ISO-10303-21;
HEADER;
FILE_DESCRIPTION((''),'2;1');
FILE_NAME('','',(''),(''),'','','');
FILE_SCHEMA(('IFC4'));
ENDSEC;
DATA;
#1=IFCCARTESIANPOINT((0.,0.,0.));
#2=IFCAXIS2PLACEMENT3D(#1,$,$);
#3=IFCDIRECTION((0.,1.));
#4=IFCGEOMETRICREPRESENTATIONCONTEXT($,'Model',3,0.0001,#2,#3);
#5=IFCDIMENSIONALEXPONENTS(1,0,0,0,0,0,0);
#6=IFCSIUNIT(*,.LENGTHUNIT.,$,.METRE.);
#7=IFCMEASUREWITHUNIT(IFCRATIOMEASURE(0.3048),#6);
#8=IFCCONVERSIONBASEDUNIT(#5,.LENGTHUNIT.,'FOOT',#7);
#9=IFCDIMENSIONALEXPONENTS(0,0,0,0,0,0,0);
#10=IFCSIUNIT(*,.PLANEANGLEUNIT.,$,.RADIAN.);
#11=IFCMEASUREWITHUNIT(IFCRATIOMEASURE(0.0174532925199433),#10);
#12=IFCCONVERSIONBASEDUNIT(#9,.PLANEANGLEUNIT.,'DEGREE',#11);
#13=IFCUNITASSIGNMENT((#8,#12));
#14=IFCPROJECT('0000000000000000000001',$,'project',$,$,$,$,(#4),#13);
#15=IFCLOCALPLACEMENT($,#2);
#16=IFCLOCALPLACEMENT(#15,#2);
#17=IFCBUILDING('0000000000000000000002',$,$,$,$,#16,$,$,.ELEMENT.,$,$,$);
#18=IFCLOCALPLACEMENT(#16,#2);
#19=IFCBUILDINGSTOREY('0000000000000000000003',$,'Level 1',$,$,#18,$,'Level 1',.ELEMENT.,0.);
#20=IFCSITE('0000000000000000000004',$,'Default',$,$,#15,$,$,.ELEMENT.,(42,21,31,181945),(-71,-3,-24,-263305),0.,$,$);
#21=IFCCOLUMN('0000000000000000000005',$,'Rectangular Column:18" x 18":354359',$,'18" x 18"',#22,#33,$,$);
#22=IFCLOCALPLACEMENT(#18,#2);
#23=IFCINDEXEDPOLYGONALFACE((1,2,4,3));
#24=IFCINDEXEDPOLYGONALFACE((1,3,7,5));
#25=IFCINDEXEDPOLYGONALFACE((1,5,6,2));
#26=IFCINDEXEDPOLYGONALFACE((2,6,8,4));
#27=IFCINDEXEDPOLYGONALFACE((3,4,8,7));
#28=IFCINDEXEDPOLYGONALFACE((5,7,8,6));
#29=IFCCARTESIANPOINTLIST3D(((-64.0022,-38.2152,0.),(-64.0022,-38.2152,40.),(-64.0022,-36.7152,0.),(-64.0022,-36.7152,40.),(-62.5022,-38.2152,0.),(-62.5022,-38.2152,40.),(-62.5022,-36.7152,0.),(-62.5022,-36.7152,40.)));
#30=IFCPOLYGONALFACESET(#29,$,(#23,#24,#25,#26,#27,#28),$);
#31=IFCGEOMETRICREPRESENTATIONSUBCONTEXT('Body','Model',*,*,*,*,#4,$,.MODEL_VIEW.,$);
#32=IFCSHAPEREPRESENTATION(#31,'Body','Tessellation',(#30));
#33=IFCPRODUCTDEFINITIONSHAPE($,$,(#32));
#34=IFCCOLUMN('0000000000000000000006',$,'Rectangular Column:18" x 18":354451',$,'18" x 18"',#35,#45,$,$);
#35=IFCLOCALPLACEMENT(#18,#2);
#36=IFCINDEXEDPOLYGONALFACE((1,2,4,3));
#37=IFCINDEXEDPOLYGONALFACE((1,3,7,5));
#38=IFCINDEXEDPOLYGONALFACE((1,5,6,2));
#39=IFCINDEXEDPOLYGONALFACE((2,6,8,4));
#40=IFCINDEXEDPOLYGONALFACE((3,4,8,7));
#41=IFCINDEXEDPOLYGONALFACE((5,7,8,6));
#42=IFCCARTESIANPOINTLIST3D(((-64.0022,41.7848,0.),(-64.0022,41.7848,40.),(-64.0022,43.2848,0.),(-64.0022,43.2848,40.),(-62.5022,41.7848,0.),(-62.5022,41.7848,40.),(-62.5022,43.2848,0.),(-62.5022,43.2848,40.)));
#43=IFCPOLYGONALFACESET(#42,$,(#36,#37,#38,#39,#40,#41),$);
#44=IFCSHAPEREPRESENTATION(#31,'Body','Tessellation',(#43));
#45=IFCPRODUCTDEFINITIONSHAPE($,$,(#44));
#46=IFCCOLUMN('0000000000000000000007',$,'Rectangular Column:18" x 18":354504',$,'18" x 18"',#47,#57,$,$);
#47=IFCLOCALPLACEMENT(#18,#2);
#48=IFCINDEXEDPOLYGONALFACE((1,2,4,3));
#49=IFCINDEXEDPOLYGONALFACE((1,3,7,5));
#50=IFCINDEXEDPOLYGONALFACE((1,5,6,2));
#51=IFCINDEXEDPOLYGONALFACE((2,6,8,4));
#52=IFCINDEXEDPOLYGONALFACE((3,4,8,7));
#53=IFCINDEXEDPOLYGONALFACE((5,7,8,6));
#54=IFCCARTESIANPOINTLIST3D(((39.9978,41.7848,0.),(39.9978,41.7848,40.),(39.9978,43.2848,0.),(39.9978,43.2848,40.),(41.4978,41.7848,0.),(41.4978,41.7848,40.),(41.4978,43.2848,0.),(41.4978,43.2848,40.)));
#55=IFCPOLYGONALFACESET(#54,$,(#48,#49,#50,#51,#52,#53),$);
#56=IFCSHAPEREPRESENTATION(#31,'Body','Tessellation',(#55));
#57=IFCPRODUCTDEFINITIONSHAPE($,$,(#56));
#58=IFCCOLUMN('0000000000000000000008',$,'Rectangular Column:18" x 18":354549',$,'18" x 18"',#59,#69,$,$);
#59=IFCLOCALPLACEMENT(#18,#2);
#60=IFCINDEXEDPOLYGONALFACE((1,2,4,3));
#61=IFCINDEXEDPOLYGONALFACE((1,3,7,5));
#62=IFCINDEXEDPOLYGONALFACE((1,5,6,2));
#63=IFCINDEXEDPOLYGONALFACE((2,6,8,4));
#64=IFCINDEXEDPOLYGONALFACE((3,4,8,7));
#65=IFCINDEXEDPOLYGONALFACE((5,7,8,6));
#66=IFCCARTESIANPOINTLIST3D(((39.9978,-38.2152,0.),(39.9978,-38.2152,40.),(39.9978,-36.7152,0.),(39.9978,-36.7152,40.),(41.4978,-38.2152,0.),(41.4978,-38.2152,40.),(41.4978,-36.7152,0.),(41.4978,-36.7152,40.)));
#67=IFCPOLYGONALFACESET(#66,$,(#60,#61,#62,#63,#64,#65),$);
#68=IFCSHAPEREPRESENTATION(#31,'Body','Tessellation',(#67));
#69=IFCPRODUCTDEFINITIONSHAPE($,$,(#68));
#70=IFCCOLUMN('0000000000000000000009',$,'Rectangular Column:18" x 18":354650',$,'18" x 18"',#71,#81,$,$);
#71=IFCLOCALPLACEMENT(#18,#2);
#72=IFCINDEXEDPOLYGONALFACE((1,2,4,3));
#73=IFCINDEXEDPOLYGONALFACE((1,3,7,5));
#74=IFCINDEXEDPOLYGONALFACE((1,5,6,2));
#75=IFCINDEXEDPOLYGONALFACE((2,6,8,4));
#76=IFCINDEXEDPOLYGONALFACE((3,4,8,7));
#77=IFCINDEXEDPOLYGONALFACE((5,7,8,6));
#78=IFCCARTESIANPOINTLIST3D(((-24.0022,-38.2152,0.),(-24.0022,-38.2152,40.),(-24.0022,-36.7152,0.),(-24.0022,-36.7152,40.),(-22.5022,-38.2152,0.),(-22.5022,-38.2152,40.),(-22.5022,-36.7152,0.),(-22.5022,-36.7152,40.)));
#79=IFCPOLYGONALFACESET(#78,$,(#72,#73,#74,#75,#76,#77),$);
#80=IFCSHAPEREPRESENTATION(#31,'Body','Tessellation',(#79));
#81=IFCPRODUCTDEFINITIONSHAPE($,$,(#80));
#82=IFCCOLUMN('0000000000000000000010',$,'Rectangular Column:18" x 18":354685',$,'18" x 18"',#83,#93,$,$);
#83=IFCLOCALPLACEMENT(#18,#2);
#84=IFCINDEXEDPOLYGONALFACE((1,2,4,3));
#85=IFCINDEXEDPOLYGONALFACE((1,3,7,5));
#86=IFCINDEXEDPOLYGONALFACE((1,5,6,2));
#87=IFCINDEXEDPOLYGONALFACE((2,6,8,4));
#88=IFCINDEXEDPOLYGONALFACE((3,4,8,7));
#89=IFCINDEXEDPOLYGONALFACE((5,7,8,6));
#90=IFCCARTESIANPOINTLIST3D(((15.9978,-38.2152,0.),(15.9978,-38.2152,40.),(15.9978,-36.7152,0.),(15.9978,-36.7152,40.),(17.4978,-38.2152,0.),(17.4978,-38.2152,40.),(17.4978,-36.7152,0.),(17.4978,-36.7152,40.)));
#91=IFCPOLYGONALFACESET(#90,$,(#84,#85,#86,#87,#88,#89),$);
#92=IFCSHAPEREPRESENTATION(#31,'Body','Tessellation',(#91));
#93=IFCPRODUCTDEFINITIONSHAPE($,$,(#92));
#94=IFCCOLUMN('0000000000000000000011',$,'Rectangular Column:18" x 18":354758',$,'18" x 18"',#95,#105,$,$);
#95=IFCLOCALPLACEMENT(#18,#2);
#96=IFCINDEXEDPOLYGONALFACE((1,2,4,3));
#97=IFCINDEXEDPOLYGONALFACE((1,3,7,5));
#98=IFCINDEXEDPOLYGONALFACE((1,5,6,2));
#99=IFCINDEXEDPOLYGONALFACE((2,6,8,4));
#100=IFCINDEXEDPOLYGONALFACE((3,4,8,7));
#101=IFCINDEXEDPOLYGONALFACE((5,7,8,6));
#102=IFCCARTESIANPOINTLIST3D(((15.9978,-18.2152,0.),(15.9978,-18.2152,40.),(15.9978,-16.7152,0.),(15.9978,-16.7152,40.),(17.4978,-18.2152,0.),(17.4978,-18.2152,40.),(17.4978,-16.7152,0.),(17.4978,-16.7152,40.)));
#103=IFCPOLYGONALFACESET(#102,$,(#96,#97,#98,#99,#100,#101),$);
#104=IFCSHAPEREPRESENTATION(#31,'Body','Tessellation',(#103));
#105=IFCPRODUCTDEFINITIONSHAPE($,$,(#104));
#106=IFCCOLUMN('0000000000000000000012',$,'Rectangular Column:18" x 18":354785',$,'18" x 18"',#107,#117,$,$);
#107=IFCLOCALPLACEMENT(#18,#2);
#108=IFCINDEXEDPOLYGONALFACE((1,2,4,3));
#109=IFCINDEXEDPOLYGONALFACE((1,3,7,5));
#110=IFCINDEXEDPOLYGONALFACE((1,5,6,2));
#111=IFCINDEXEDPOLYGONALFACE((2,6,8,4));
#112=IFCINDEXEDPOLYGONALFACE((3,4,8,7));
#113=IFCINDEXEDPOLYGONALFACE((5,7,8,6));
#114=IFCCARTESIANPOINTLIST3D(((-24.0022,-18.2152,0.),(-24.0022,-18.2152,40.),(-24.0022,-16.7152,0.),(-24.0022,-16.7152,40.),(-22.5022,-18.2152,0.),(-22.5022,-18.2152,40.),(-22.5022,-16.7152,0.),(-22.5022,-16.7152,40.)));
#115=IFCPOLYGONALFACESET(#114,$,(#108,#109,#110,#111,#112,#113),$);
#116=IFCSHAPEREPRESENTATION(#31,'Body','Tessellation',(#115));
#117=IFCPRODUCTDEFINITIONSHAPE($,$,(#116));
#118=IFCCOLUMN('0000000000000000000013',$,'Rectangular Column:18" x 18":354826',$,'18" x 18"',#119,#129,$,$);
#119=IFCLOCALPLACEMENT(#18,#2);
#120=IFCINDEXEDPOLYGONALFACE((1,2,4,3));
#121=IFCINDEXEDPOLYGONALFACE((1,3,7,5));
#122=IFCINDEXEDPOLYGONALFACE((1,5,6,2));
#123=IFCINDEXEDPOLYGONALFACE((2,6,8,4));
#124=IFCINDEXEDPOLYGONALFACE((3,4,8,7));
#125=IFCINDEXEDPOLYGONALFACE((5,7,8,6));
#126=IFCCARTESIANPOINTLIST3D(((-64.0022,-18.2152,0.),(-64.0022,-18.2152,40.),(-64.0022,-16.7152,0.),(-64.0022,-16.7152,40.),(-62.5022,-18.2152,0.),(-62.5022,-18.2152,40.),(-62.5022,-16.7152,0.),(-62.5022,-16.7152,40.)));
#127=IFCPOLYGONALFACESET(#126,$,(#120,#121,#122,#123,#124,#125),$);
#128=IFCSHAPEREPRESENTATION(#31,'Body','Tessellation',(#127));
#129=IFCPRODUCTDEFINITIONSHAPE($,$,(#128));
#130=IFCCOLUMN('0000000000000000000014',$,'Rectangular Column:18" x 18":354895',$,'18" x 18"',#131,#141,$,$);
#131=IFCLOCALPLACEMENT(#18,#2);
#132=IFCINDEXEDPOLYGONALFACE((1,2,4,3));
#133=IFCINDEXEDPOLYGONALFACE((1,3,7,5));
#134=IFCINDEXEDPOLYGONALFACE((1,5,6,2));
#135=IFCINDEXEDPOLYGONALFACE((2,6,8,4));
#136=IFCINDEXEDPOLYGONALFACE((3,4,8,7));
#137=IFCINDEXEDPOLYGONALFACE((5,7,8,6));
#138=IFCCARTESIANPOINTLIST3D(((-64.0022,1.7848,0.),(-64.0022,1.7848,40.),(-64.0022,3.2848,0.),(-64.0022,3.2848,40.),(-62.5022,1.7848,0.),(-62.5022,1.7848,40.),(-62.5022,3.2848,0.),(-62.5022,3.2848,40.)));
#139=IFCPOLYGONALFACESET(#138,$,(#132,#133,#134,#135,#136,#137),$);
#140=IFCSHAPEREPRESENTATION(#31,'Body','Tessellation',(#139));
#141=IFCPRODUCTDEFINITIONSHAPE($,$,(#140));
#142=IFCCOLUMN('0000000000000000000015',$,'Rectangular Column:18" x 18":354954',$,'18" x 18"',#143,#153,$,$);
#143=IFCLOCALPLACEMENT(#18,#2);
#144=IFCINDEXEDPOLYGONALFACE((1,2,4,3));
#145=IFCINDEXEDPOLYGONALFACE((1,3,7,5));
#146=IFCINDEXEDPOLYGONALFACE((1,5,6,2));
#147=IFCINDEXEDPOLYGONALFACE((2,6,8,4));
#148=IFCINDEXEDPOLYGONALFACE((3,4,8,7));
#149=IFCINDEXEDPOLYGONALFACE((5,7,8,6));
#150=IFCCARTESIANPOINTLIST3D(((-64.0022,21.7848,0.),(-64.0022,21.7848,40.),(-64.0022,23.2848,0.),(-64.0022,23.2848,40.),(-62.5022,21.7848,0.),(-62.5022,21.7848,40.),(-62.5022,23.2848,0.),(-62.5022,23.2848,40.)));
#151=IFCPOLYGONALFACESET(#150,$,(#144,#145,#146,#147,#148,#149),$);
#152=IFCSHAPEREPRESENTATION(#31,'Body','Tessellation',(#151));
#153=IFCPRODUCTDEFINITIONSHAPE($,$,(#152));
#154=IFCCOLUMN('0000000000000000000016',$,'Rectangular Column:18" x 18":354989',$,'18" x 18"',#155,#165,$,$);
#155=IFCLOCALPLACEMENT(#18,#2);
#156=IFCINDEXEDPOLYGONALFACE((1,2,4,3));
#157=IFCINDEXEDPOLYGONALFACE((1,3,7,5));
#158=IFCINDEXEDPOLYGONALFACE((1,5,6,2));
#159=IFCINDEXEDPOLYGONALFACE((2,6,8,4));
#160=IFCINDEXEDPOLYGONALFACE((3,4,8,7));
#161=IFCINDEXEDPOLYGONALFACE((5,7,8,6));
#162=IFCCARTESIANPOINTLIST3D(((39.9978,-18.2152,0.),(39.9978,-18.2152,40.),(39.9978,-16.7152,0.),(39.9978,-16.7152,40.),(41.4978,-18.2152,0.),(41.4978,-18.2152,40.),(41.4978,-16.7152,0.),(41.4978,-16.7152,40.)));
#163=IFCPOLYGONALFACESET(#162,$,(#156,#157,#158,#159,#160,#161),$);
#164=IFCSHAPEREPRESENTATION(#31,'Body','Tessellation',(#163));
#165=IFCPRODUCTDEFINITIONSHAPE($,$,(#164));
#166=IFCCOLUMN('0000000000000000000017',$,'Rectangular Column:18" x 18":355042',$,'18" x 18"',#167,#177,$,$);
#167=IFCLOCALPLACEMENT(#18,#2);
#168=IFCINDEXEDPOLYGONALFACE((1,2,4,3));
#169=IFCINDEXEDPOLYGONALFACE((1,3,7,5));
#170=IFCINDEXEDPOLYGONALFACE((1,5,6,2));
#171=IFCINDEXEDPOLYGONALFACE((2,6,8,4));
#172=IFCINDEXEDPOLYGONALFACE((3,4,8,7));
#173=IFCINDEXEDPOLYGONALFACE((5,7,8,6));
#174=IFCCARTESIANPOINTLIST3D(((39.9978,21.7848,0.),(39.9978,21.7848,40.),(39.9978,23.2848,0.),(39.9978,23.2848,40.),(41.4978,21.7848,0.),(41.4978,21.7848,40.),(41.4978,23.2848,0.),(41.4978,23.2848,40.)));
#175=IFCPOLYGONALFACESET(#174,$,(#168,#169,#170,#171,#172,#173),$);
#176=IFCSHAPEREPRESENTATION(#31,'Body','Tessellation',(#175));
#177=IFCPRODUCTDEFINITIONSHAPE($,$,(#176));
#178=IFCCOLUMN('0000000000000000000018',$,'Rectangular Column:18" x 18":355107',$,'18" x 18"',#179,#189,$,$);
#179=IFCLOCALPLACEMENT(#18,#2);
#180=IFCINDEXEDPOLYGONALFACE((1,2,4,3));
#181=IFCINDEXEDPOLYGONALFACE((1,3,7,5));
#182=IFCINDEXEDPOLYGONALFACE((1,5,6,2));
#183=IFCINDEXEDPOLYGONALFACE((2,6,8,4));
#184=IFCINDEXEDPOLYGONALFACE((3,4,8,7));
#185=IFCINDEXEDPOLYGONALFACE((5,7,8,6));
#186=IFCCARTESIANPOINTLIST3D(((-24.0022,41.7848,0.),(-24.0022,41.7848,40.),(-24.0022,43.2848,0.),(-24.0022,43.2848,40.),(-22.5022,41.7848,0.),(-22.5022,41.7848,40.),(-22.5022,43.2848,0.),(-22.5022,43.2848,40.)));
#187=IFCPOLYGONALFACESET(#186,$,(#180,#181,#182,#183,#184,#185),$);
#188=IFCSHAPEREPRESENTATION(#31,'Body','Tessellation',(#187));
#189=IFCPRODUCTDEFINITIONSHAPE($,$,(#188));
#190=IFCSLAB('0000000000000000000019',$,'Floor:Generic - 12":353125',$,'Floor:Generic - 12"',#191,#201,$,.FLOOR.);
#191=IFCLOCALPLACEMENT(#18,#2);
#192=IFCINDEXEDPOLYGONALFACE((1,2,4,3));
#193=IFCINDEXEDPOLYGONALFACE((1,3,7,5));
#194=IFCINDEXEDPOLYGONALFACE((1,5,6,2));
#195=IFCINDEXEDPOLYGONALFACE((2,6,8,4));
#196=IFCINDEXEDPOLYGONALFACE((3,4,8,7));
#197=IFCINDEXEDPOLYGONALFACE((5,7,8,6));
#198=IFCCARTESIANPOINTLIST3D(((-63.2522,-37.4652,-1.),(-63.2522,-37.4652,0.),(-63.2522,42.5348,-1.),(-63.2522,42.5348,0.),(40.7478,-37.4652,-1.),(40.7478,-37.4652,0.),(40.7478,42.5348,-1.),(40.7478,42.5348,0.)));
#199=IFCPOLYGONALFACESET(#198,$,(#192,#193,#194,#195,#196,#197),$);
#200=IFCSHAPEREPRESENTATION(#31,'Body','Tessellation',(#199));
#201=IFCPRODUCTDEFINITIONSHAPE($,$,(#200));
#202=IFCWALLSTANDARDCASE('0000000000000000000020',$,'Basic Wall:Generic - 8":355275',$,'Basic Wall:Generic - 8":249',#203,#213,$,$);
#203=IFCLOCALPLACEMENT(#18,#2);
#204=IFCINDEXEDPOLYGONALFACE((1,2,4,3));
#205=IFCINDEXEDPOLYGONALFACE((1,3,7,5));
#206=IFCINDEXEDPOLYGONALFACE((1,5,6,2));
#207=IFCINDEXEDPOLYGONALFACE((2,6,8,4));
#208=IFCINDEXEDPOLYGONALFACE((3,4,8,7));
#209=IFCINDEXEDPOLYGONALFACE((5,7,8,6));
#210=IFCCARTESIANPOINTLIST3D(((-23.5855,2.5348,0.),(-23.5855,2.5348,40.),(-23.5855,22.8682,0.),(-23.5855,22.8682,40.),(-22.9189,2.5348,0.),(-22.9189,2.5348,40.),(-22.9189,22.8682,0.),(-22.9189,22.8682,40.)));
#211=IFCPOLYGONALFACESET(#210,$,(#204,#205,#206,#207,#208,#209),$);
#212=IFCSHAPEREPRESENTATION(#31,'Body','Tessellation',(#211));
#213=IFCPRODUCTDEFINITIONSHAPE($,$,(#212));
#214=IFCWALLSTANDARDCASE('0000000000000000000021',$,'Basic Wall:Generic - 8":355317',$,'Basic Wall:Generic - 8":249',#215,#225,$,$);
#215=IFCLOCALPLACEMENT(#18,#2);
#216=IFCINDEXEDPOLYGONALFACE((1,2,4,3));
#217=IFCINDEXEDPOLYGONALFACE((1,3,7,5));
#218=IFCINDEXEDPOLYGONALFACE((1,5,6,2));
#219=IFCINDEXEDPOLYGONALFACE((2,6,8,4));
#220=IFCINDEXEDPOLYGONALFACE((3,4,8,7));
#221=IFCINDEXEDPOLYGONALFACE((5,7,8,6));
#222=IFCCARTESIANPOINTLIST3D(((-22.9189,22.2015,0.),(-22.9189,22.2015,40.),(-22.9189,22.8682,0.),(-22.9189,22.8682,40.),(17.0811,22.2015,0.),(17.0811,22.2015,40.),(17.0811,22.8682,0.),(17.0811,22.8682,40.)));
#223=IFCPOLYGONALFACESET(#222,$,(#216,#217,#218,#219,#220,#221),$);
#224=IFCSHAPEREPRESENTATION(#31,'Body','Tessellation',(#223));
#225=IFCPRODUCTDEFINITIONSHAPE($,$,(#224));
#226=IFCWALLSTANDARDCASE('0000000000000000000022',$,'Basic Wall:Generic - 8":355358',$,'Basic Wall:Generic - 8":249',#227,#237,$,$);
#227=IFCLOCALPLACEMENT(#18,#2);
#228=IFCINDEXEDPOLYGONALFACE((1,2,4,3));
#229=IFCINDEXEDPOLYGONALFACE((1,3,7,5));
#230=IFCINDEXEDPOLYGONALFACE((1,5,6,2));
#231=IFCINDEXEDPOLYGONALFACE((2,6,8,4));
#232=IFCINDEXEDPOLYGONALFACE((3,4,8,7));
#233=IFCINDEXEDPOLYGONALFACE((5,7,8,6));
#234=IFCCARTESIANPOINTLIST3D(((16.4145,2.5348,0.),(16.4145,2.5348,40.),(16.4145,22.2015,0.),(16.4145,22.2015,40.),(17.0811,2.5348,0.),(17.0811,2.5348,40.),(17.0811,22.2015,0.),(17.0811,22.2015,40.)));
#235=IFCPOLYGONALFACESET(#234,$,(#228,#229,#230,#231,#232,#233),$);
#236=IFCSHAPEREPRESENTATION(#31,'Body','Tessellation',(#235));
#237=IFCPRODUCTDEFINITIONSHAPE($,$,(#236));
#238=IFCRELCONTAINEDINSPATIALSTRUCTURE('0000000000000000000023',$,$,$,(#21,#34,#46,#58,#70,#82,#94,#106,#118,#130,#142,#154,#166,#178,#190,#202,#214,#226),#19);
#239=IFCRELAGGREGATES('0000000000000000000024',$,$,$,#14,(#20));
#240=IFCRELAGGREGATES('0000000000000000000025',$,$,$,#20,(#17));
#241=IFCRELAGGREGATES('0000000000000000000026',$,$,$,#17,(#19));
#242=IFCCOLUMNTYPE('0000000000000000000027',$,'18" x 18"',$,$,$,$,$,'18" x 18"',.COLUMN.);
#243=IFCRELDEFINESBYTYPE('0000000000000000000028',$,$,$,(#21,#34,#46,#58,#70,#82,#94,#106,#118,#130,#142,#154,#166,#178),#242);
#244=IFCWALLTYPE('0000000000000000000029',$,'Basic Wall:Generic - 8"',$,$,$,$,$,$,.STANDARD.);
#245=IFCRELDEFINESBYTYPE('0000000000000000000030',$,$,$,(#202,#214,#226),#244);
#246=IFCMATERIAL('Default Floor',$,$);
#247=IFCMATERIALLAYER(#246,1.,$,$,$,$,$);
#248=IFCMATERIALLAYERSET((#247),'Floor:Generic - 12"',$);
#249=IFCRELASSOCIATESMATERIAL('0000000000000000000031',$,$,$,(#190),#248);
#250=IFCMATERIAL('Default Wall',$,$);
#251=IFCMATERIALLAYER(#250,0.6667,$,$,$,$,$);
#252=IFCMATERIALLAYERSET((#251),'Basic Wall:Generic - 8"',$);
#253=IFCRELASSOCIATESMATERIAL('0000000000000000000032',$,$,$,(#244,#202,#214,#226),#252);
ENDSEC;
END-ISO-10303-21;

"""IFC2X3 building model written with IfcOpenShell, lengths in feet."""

from ifc_helpers import new_model, entity, si_unit, converted_unit, direction, frame, frame_2d, origin, origin_2d_with_axis, place, context, subcontext, project, spatial, rectangle, extrude, source, transform, mapped, material, layer, layer_set, layer_usage, type_object, type_shapes, element, save


model = new_model("IFC2X3")

# Units and contexts
model_context = context("Model", 3, precision=0.0001, world=origin(), true_north=direction((0.0, 1.0)))
body_context = subcontext(model_context, "Body", "Model", "MODEL_VIEW")
ifc_project = project(units=[converted_unit("LENGTHUNIT", "FOOT", entity("IfcRatioMeasure", 0.3048), si_unit("LENGTHUNIT", "METRE"), dimensions=[1, 0, 0, 0, 0, 0, 0]), converted_unit("PLANEANGLEUNIT", "DEGREE", entity("IfcRatioMeasure", 0.0174532925199433), si_unit("PLANEANGLEUNIT", "RADIAN"), dimensions=[0, 0, 0, 0, 0, 0, 0])], contexts=[model_context])

# Site, building, storey
site_placement = place(None, origin())
site = spatial("IfcSite", under=ifc_project, at=site_placement, Name="Default", CompositionType="ELEMENT", RefLatitude=(42, 21, 31, 181945), RefLongitude=(-71, -3, -24, -263305), RefElevation=0.0)
building_placement = place(site_placement, origin())
building = spatial("IfcBuilding", under=site, at=building_placement, CompositionType="ELEMENT")
storey_placement = place(building_placement, origin())
storey = spatial("IfcBuildingStorey", under=building, at=storey_placement, Name="Level 1", LongName="Level 1", CompositionType="ELEMENT", Elevation=0.0)

# Columns
column_type = type_object("IfcColumnType", Name="18\" x 18\"", ElementType="18\" x 18\"", PredefinedType="COLUMN")
shared_shape = source(origin(), body_context, "Body", "SweptSolid", [
    extrude(rectangle(XDim=1.5, YDim=1.5, at=origin_2d_with_axis()), frame((0.0, 0.0, 0.0), z_axis=(0.0, 0.0, 1.0), x_axis=(0.0, -1.0, 0.0)), (0.0, 0.0, 1.0), 40.0),
])
type_shapes(column_type, [shared_shape])
for number, where, name in (
    (1, (-63.2522, -37.4652, 0.0), "Rectangular Column:18\" x 18\":354359"),
    (2, (-63.2522, 42.5348, 0.0), "Rectangular Column:18\" x 18\":354451"),
    (3, (40.7478, 42.5348, 0.0), "Rectangular Column:18\" x 18\":354504"),
    (4, (40.7478, -37.4652, 0.0), "Rectangular Column:18\" x 18\":354549"),
    (5, (-23.2522, -37.4652, 0.0), "Rectangular Column:18\" x 18\":354650"),
    (6, (16.7478, -37.4652, 0.0), "Rectangular Column:18\" x 18\":354685"),
    (7, (16.7478, -17.4652, 0.0), "Rectangular Column:18\" x 18\":354758"),
    (8, (-23.2522, -17.4652, 0.0), "Rectangular Column:18\" x 18\":354785"),
    (9, (-63.2522, -17.4652, 0.0), "Rectangular Column:18\" x 18\":354826"),
    (10, (-63.2522, 2.5348, 0.0), "Rectangular Column:18\" x 18\":354895"),
    (11, (-63.2522, 22.5348, 0.0), "Rectangular Column:18\" x 18\":354954"),
    (12, (40.7478, -17.4652, 0.0), "Rectangular Column:18\" x 18\":354989"),
    (13, (40.7478, 22.5348, 0.0), "Rectangular Column:18\" x 18\":355042"),
    (14, (-23.2522, 42.5348, 0.0), "Rectangular Column:18\" x 18\":355107"),
):
    element("IfcColumn", number, at=place(storey_placement, frame(where)), inside=storey, type_object=column_type, Name=name, ObjectType="18\" x 18\"", context=body_context, shape_type="MappedRepresentation", body=[
        mapped(shared_shape, transform((0.0, 0.0, 0.0), scale=1.0)),
    ])

# Slab
ifc_material_1 = material(Name="Default Floor")
ifc_layer_1 = layer(ifc_material_1, 1.0)
ifc_layer_set_1 = layer_set([ifc_layer_1], Name="Floor:Generic - 12\"")
ifc_layer_usage_1 = layer_usage(ifc_layer_set_1, "AXIS3", "POSITIVE", 0.0)
slab_placement = place(storey_placement, origin())
element("IfcSlab", 15, at=slab_placement, inside=storey, material=ifc_layer_usage_1, Name="Floor:Generic - 12\":353125", ObjectType="Floor:Generic - 12\"", PredefinedType="FLOOR", context=body_context, shape_type="SweptSolid", body=[
    extrude(rectangle(XDim=80.0, YDim=104.0, at=origin_2d_with_axis()), frame((-11.2522, 2.5348, 0.0), z_axis=(0.0, 0.0, -1.0), x_axis=(0.0, 1.0, 0.0)), (0.0, 0.0, 1.0), 1.0),
])

# Walls
ifc_material_2 = material(Name="Default Wall")
ifc_layer_2 = layer(ifc_material_2, 0.6667)
ifc_layer_set_2 = layer_set([ifc_layer_2], Name="Basic Wall:Generic - 8\"")
ifc_layer_usage_2 = layer_usage(ifc_layer_set_2, "AXIS2", "NEGATIVE", 0.3333)
wall_type = type_object("IfcWallType", Name="Basic Wall:Generic - 8\"", PredefinedType="STANDARD", material=ifc_layer_set_2)
wall_1_placement = place(storey_placement, frame((-23.2522, 2.5348, 0.0), z_axis=(0.0, 0.0, 1.0), x_axis=(0.0, 1.0, 0.0)))
element("IfcWallStandardCase", 16, at=wall_1_placement, inside=storey, type_object=wall_type, material=ifc_layer_usage_2, Name="Basic Wall:Generic - 8\":355275", ObjectType="Basic Wall:Generic - 8\":249", context=body_context, shape_type="SweptSolid", body=[
    extrude(rectangle(XDim=20.3333, YDim=0.6667, at=frame_2d((10.1667, 0.0), x_axis=(-1.0, 0.0))), origin(), (0.0, 0.0, 1.0), 40.0),
])
ifc_layer_usage_3 = layer_usage(ifc_layer_set_2, "AXIS2", "NEGATIVE", 0.3333)
wall_2_placement = place(storey_placement, frame((-22.9189, 22.5348, 0.0)))
element("IfcWallStandardCase", 17, at=wall_2_placement, inside=storey, type_object=wall_type, material=ifc_layer_usage_3, Name="Basic Wall:Generic - 8\":355317", ObjectType="Basic Wall:Generic - 8\":249", context=body_context, shape_type="SweptSolid", body=[
    extrude(rectangle(XDim=40.0, YDim=0.6667, at=frame_2d((20.0, 0.0), x_axis=(-1.0, 0.0))), origin(), (0.0, 0.0, 1.0), 40.0),
])
ifc_layer_usage_4 = layer_usage(ifc_layer_set_2, "AXIS2", "NEGATIVE", 0.3333)
wall_3_placement = place(storey_placement, frame((16.7478, 22.2015, 0.0), z_axis=(0.0, 0.0, 1.0), x_axis=(0.0, -1.0, 0.0)))
element("IfcWallStandardCase", 18, at=wall_3_placement, inside=storey, type_object=wall_type, material=ifc_layer_usage_4, Name="Basic Wall:Generic - 8\":355358", ObjectType="Basic Wall:Generic - 8\":249", context=body_context, shape_type="SweptSolid", body=[
    extrude(rectangle(XDim=19.6667, YDim=0.6667, at=frame_2d((9.8333, 0.0), x_axis=(-1.0, 0.0))), origin(), (0.0, 0.0, 1.0), 40.0),
])

save(model, "model.ifc")
